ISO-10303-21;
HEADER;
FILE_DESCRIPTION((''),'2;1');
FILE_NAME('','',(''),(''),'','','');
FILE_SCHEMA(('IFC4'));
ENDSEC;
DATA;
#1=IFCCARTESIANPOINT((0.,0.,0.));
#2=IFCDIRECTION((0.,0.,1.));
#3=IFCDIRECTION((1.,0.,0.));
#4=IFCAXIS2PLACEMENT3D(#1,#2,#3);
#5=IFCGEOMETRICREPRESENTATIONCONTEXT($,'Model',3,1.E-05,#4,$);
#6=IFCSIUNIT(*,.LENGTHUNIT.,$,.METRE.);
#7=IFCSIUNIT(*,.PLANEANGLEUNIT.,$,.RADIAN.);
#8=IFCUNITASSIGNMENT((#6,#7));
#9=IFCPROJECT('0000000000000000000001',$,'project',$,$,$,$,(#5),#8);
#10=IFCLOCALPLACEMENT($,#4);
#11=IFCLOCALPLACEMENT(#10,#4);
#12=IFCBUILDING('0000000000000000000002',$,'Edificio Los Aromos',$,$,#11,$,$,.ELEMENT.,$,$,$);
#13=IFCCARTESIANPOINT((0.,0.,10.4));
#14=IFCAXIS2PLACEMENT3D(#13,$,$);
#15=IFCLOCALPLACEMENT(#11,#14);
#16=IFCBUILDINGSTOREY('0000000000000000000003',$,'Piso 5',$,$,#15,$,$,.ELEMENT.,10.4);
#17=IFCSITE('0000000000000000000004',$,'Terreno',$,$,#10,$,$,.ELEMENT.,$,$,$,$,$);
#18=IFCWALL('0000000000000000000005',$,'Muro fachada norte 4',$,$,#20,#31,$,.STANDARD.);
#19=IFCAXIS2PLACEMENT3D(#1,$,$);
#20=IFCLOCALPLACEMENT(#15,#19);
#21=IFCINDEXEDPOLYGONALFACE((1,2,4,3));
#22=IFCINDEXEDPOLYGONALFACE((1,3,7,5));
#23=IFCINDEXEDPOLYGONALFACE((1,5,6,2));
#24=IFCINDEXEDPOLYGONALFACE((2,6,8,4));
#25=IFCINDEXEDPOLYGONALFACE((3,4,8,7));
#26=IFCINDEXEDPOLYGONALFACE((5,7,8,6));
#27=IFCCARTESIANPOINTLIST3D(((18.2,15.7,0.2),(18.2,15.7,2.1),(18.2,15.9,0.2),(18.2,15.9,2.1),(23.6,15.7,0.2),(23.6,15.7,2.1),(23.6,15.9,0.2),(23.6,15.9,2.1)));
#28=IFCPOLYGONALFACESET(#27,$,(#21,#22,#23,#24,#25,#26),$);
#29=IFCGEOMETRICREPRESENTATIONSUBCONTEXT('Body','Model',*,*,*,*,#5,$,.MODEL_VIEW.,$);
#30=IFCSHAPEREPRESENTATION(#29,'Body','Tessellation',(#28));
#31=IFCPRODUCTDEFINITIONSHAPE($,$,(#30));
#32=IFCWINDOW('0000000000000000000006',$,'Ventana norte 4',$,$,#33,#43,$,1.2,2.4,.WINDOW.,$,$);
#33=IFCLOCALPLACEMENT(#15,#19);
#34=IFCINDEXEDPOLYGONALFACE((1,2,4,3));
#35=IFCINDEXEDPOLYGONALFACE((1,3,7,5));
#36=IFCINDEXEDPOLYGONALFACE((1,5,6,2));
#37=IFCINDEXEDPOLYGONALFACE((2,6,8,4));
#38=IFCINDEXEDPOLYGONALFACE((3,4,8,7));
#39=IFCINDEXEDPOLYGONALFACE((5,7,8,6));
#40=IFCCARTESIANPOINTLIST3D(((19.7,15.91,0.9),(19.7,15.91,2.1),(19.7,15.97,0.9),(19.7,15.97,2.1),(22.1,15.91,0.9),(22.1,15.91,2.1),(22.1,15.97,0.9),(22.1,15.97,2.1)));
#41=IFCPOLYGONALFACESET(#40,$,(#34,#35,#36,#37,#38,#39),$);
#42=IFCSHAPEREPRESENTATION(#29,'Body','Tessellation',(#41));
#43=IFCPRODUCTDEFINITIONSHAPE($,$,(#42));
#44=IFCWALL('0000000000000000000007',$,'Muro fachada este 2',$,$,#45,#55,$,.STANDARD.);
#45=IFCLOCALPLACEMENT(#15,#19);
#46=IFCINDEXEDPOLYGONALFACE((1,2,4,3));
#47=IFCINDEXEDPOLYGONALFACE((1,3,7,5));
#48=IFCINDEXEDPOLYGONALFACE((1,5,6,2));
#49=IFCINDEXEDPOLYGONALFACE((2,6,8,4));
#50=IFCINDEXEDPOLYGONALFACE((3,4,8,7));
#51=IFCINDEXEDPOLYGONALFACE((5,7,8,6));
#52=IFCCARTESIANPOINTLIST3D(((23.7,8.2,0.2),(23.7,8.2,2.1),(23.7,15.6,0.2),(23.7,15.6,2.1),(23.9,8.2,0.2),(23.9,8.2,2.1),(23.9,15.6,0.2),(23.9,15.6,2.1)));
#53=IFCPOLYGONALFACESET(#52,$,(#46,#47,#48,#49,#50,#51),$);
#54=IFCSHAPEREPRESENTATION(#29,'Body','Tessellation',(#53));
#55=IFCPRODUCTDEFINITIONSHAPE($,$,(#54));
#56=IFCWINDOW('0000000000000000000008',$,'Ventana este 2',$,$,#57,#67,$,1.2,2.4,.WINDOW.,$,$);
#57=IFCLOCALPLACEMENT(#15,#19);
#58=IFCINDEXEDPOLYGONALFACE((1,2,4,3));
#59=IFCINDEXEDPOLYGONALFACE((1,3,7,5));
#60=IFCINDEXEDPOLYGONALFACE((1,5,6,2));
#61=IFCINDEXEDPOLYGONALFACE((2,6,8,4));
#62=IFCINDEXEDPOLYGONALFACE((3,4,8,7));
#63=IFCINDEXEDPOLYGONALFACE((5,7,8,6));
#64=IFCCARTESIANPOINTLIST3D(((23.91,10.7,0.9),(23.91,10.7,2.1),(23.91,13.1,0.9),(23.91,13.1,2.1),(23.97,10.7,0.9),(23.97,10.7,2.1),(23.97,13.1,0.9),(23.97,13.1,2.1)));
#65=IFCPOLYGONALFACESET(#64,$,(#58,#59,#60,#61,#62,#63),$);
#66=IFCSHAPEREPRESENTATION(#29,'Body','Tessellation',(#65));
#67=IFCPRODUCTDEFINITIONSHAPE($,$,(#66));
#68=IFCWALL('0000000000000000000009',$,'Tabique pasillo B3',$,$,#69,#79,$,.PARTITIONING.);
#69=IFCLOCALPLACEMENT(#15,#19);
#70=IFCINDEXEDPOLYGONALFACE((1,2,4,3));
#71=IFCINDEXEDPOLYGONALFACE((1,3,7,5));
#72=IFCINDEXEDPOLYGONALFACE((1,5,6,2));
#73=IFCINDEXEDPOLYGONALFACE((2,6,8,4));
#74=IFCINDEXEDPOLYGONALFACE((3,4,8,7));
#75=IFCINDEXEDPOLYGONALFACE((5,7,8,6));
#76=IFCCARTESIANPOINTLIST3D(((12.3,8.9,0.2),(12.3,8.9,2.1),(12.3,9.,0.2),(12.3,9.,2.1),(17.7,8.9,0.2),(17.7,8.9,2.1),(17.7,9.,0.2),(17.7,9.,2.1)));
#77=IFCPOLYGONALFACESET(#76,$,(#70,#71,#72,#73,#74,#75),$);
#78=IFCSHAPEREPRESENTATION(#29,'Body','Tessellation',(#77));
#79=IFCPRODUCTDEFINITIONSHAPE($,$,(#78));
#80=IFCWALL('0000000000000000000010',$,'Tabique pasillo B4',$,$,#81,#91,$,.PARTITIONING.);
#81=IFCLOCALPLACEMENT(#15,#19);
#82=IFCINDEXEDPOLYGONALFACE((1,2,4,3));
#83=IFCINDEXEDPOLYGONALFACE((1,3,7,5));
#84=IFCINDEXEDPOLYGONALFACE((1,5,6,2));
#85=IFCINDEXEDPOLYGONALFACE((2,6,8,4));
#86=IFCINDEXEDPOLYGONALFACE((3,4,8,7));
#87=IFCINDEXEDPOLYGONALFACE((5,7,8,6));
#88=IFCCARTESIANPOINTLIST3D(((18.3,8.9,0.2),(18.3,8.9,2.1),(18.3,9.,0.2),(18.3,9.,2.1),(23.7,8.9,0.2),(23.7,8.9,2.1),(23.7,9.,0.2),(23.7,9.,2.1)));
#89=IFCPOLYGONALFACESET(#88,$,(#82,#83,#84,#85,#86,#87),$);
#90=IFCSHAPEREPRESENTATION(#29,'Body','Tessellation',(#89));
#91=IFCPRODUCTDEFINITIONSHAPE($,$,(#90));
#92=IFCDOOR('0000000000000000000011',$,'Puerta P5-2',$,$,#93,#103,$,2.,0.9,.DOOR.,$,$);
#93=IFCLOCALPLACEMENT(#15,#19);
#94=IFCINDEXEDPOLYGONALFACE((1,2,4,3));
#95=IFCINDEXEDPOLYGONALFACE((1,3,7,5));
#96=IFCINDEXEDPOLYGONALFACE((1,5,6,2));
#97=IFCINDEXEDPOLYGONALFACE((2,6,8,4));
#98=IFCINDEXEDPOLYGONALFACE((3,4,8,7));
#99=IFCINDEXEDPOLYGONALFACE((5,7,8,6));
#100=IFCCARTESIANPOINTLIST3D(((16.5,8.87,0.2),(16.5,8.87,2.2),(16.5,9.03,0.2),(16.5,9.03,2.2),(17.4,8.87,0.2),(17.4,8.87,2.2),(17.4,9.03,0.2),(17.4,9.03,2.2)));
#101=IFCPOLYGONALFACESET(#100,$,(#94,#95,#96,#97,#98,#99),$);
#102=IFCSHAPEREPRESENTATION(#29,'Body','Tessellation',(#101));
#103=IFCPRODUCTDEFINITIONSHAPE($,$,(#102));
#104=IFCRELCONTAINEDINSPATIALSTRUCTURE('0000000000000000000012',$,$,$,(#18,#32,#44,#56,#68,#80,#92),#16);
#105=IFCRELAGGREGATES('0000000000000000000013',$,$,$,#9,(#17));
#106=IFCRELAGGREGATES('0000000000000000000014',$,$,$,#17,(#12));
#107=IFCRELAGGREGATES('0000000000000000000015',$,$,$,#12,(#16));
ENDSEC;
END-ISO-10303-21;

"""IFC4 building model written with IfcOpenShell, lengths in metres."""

from ifc_helpers import new_model, si_unit, frame, frame_2d, origin_with_axes, place, context, subcontext, project, spatial, rectangle, extrude, element, save


model = new_model("IFC4")

# Units and contexts
model_context = context("Model", 3, precision=1e-05, world=origin_with_axes())
body_context = subcontext(model_context, "Body", "Model", "MODEL_VIEW")
ifc_project = project(units=[si_unit("LENGTHUNIT", "METRE"), si_unit("PLANEANGLEUNIT", "RADIAN")], contexts=[model_context])

# Site, building, storey
site_placement = place(None, origin_with_axes())
site = spatial("IfcSite", under=ifc_project, at=site_placement, Name="Terreno", CompositionType="ELEMENT")
building_placement = place(site_placement, origin_with_axes())
building = spatial("IfcBuilding", under=site, at=building_placement, Name="Edificio Los Aromos", CompositionType="ELEMENT")
storey_placement = place(building_placement, frame((0.0, 0.0, 10.4)))
storey = spatial("IfcBuildingStorey", under=building, at=storey_placement, Name="Piso 5", CompositionType="ELEMENT", Elevation=10.4)

# Wall
wall_1_placement = place(storey_placement, frame((18.2, 15.7, 0.2)))
element("IfcWall", 1, at=wall_1_placement, inside=storey, Name="Muro fachada norte 4", PredefinedType="STANDARD", context=body_context, shape_type="SweptSolid", body=[
    extrude(rectangle(XDim=5.4, YDim=0.2, at=frame_2d((2.7, 0.1))), origin_with_axes(), (0.0, 0.0, 1.0), 1.9),
])

# Window
window_1_placement = place(storey_placement, frame((19.7, 15.91, 0.9)))
element("IfcWindow", 2, at=window_1_placement, inside=storey, Name="Ventana norte 4", OverallHeight=1.2, OverallWidth=2.4, PredefinedType="WINDOW", context=body_context, shape_type="SweptSolid", body=[
    extrude(rectangle(XDim=2.4, YDim=0.06, at=frame_2d((1.2, 0.03))), origin_with_axes(), (0.0, 0.0, 1.0), 1.2),
])

# Wall
wall_2_placement = place(storey_placement, frame((23.7, 8.2, 0.2)))
element("IfcWall", 3, at=wall_2_placement, inside=storey, Name="Muro fachada este 2", PredefinedType="STANDARD", context=body_context, shape_type="SweptSolid", body=[
    extrude(rectangle(XDim=0.2, YDim=7.4, at=frame_2d((0.1, 3.7))), origin_with_axes(), (0.0, 0.0, 1.0), 1.9),
])

# Window
window_2_placement = place(storey_placement, frame((23.91, 10.7, 0.9)))
element("IfcWindow", 4, at=window_2_placement, inside=storey, Name="Ventana este 2", OverallHeight=1.2, OverallWidth=2.4, PredefinedType="WINDOW", context=body_context, shape_type="SweptSolid", body=[
    extrude(rectangle(XDim=0.06, YDim=2.4, at=frame_2d((0.03, 1.2))), origin_with_axes(), (0.0, 0.0, 1.0), 1.2),
])

# Walls
for number, where, name in (
    (5, (12.3, 8.9, 0.2), "Tabique pasillo B3"),
    (6, (18.3, 8.9, 0.2), "Tabique pasillo B4"),
):
    element("IfcWall", number, at=place(storey_placement, frame(where)), inside=storey, Name=name, PredefinedType="PARTITIONING", context=body_context, shape_type="SweptSolid", body=[
        extrude(rectangle(XDim=5.4, YDim=0.1, at=frame_2d((2.7, 0.05))), origin_with_axes(), (0.0, 0.0, 1.0), 1.9),
    ])

# Door
door_placement = place(storey_placement, frame((16.5, 8.87, 0.2)))
element("IfcDoor", 7, at=door_placement, inside=storey, Name="Puerta P5-2", OverallHeight=2.0, OverallWidth=0.9, PredefinedType="DOOR", context=body_context, shape_type="SweptSolid", body=[
    extrude(rectangle(XDim=0.9, YDim=0.16, at=frame_2d((0.45, 0.08))), origin_with_axes(), (0.0, 0.0, 1.0), 2.0),
])

save(model, "model.ifc")
